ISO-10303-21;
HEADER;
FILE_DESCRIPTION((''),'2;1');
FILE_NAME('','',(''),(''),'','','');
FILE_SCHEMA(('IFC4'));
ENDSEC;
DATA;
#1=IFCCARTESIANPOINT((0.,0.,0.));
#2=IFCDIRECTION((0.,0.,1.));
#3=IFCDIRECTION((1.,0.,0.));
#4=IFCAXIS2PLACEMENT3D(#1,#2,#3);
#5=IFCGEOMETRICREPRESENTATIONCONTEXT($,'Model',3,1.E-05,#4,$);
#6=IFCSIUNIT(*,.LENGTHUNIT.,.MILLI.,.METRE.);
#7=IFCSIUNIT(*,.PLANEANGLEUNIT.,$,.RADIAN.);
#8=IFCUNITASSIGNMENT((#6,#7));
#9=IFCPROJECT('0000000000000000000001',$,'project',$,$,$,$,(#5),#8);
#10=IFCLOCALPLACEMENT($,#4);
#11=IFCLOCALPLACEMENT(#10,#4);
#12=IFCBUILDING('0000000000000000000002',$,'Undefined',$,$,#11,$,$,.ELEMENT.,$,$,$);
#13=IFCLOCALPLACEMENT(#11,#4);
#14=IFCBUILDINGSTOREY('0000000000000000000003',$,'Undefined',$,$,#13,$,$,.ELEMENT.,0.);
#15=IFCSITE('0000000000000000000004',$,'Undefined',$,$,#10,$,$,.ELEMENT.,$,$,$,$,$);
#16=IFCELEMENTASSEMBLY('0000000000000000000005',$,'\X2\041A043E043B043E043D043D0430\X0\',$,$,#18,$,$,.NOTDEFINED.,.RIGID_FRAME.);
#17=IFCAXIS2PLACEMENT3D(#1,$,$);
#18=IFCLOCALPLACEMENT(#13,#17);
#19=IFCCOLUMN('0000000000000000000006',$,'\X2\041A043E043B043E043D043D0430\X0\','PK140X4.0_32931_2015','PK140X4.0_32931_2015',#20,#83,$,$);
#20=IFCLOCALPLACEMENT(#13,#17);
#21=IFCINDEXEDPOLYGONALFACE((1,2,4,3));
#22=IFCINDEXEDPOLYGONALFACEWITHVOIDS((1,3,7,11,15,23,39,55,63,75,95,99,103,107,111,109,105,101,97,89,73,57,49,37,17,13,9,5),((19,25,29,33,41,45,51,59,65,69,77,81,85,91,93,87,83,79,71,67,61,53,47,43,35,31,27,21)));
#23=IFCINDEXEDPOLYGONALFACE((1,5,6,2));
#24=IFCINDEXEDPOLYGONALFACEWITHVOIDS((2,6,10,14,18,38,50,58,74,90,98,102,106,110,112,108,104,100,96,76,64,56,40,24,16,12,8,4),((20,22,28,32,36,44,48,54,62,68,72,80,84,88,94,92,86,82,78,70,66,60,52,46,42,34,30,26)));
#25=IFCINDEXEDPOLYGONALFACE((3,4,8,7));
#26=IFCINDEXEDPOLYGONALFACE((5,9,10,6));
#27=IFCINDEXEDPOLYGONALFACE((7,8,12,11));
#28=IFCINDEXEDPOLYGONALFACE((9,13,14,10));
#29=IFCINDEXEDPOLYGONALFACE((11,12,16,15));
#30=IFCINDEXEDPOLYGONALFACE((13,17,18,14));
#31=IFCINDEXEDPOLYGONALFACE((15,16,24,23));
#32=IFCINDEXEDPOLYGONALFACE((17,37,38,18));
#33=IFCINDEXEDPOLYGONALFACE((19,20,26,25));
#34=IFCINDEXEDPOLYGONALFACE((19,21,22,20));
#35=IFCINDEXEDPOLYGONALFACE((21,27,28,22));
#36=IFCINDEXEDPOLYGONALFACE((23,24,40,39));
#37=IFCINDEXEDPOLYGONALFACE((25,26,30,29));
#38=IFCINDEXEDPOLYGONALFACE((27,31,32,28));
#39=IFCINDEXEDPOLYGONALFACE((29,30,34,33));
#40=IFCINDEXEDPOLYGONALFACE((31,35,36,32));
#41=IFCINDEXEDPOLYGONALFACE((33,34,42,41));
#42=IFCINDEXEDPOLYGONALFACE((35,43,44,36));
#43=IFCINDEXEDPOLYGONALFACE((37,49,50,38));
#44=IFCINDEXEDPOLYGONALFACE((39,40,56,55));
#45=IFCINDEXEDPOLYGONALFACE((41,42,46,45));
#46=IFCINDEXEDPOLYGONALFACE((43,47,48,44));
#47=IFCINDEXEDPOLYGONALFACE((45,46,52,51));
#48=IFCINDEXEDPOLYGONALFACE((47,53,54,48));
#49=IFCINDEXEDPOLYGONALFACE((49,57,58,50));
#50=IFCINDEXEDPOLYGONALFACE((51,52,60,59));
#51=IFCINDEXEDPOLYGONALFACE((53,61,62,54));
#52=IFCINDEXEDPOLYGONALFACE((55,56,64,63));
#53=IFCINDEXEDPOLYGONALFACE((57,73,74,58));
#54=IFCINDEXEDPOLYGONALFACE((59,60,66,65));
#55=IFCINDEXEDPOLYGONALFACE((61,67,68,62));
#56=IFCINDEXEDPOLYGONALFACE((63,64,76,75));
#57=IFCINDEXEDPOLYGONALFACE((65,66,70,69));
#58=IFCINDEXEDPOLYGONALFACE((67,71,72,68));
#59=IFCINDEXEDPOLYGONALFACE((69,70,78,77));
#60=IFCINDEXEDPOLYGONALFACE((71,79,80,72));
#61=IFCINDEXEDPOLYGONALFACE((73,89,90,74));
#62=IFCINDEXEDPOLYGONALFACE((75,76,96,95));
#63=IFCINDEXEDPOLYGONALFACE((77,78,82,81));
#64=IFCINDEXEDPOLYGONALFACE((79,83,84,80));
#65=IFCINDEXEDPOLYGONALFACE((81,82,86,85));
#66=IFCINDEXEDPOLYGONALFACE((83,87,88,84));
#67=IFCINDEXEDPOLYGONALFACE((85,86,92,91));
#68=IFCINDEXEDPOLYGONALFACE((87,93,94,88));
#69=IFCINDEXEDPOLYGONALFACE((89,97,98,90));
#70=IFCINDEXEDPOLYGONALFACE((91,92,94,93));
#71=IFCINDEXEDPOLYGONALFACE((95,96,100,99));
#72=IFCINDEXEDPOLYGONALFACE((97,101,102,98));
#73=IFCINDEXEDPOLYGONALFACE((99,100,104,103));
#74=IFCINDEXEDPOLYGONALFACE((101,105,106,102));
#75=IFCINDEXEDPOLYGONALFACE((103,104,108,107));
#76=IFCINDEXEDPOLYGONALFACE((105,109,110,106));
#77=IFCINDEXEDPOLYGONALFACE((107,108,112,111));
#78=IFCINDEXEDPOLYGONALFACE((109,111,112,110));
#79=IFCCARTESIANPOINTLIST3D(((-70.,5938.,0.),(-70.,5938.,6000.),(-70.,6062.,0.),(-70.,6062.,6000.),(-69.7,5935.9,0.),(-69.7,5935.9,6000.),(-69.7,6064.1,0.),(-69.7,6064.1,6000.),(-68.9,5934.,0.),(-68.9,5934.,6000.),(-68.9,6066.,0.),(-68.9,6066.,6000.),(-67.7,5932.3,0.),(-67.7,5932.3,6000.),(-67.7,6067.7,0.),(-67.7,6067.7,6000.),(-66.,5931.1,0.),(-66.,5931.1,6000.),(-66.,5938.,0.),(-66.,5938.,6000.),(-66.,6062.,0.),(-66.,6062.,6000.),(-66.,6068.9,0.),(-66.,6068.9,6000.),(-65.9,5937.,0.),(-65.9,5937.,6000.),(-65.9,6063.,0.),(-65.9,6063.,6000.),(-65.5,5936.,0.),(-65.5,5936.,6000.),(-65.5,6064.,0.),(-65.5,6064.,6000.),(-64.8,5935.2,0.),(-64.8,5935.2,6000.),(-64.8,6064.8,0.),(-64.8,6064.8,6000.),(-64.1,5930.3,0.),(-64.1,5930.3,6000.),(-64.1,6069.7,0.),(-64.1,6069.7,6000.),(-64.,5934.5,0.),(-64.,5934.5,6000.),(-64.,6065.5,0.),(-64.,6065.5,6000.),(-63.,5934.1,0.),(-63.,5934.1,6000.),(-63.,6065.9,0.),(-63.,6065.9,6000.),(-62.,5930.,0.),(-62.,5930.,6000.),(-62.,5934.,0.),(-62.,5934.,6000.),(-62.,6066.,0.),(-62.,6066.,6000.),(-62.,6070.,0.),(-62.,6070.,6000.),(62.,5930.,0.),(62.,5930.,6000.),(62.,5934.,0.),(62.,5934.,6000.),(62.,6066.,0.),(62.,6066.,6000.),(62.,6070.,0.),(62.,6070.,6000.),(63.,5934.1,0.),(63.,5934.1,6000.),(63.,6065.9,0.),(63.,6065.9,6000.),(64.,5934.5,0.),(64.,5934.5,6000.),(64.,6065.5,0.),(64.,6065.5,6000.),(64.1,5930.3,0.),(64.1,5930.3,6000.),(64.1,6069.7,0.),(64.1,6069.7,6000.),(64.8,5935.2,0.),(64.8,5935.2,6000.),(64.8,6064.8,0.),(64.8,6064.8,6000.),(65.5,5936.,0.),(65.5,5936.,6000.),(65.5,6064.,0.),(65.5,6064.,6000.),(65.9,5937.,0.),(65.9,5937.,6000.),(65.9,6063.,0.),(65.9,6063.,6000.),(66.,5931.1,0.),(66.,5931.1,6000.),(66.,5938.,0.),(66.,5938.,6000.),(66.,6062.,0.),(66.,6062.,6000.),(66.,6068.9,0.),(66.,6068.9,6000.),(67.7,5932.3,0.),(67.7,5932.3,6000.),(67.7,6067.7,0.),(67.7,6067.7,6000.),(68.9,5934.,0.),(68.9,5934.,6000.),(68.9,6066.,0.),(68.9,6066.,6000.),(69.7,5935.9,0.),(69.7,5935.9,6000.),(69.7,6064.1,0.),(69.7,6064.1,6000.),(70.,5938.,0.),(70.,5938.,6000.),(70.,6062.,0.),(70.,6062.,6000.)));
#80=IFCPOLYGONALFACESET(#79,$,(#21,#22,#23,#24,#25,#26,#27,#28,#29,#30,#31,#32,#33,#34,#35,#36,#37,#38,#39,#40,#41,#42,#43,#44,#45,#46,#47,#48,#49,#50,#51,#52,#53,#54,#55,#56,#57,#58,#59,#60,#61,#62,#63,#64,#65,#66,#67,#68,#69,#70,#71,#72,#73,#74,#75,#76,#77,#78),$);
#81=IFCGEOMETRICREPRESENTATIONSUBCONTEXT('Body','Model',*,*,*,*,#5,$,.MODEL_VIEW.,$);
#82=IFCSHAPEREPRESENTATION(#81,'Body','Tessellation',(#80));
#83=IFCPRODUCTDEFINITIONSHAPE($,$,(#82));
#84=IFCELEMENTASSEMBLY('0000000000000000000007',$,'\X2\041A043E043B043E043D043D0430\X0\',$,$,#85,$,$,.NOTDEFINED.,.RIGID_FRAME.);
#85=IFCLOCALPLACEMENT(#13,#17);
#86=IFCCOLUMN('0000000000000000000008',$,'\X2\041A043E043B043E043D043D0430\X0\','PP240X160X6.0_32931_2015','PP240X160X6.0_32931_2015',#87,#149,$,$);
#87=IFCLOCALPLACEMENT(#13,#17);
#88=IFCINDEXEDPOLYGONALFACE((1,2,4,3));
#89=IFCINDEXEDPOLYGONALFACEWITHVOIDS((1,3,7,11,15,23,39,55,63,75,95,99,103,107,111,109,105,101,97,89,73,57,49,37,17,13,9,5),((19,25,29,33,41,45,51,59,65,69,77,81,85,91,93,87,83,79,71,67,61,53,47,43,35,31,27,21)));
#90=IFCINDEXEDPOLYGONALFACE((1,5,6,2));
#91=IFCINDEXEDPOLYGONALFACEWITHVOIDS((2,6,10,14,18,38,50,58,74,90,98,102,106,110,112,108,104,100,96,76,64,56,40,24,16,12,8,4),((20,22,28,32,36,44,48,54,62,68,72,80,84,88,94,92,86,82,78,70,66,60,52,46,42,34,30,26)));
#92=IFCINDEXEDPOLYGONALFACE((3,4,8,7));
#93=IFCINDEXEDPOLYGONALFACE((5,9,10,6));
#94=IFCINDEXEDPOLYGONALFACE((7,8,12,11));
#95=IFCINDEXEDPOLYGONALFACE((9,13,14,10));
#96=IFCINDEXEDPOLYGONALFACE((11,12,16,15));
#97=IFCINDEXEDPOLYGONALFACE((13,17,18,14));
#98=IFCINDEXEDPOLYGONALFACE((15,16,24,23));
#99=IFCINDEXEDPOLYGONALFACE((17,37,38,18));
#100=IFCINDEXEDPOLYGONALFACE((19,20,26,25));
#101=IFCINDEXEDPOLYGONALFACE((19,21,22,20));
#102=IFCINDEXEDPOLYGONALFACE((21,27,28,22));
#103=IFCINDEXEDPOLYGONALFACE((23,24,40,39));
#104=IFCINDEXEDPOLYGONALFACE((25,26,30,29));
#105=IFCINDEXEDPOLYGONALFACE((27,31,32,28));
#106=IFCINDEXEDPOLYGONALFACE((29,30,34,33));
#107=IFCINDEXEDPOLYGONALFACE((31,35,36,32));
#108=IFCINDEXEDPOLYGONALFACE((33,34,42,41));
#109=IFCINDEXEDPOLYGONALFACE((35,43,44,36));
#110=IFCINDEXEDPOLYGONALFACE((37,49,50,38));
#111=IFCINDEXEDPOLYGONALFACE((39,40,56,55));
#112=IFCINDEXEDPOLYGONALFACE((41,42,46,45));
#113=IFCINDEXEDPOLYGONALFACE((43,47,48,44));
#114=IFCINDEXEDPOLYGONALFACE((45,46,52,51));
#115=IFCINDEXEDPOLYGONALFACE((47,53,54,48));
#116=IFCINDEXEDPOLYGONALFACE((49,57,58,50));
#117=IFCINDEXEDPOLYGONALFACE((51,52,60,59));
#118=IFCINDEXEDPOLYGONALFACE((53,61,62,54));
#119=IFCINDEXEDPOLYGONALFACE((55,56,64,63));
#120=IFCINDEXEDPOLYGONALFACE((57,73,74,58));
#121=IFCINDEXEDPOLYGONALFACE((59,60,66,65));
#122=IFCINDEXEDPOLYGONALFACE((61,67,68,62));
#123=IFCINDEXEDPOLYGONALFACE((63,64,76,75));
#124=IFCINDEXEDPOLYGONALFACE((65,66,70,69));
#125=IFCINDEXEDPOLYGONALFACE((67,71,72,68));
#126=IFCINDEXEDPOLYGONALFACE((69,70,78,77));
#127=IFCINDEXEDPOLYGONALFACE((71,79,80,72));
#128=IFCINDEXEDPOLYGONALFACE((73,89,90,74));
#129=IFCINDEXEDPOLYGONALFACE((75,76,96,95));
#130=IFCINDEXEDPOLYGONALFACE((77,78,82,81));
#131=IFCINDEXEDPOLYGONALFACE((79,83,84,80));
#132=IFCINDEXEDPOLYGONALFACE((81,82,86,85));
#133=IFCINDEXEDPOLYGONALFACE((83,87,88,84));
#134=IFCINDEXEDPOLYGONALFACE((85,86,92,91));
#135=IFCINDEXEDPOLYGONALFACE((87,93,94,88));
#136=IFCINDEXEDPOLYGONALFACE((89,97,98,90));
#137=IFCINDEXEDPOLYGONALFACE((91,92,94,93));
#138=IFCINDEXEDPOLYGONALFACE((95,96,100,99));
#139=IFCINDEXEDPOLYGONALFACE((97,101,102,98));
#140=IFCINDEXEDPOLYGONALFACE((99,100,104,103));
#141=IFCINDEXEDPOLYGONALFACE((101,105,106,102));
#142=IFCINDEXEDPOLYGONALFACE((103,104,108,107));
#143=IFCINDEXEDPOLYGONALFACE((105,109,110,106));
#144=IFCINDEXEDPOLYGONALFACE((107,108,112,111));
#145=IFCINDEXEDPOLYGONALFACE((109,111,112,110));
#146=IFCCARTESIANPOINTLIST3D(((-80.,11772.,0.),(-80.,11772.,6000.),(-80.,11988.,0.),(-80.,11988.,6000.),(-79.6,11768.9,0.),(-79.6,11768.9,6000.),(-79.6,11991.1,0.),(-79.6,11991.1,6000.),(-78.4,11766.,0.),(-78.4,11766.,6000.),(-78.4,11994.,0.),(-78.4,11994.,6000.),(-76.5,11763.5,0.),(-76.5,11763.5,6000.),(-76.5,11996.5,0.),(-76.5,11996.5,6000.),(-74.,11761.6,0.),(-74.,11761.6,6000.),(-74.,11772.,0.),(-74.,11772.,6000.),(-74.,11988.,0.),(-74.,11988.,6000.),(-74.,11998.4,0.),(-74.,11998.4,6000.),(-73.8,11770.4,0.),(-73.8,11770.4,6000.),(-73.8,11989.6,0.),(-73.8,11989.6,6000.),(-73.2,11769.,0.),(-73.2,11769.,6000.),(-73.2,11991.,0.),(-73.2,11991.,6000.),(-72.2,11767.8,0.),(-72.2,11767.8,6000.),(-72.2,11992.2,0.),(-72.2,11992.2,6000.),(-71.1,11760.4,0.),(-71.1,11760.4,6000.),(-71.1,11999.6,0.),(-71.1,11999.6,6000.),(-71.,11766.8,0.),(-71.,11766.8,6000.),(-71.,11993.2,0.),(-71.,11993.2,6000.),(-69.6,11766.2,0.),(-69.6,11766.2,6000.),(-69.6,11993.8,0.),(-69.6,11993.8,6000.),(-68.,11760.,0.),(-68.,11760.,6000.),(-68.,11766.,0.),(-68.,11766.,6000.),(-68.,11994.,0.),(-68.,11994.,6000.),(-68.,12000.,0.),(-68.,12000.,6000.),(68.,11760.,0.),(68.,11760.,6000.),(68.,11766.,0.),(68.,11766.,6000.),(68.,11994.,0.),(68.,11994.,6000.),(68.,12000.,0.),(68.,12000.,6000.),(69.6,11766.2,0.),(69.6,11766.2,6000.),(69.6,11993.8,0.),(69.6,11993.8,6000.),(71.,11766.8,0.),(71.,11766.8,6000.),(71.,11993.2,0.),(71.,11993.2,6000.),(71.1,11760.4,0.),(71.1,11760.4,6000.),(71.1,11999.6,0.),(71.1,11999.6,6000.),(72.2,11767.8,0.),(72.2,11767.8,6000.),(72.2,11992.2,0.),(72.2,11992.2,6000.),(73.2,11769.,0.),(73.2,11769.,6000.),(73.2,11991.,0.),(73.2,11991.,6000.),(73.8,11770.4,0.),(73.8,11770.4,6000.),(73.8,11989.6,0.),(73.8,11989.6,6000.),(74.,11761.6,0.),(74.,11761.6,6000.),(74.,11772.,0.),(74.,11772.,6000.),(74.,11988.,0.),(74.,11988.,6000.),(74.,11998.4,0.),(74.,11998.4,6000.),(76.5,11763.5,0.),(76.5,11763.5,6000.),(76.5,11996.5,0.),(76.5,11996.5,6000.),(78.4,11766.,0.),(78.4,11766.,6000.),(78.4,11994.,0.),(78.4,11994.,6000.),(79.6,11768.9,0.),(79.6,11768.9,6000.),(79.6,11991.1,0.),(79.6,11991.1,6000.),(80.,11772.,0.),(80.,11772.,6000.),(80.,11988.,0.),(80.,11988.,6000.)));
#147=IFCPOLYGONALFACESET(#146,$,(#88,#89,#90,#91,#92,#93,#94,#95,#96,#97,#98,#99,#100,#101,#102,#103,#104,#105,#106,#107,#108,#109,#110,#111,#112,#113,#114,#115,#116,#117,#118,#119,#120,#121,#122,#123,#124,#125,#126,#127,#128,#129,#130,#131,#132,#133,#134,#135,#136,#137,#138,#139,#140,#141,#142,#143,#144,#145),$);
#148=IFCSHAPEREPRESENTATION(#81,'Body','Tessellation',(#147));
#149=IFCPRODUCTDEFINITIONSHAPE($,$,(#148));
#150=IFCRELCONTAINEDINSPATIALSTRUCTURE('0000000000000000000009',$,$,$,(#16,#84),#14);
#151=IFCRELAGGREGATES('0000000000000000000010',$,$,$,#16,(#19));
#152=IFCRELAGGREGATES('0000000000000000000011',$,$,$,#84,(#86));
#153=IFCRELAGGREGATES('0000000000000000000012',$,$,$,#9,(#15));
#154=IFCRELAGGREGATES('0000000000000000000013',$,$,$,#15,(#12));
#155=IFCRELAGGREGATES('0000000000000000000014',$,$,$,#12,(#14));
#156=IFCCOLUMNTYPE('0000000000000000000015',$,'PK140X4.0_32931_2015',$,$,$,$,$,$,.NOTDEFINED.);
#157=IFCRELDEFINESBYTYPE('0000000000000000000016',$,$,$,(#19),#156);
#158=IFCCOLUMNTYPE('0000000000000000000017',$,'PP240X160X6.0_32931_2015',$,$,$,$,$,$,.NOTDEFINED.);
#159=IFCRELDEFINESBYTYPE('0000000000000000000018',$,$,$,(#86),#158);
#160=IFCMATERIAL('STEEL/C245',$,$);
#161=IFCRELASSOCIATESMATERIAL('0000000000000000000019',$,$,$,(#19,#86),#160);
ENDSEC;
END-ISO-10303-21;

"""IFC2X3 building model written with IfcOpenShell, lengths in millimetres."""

from ifc_helpers import new_model, si_unit, frame, origin_with_axes, origin_2d_with_axis, place, context, subcontext, project, spatial, hollow_rectangle, extrude, material, type_object, element, aggregate, save


model = new_model("IFC2X3")

# Units and contexts
model_context = context("Model", 3, precision=1e-05, world=origin_with_axes())
body_context = subcontext(model_context, "Body", "Model", "MODEL_VIEW")
ifc_project = project(units=[si_unit("LENGTHUNIT", "METRE", prefix="MILLI"), si_unit("PLANEANGLEUNIT", "RADIAN")], contexts=[model_context])

# Site, building, storey
site_placement = place(None, origin_with_axes())
site = spatial("IfcSite", under=ifc_project, at=site_placement, Name="Undefined", CompositionType="ELEMENT")
building_placement = place(site_placement, origin_with_axes())
building = spatial("IfcBuilding", under=site, at=building_placement, Name="Undefined", CompositionType="ELEMENT")
storey_placement = place(building_placement, origin_with_axes())
storey = spatial("IfcBuildingStorey", under=building, at=storey_placement, Name="Undefined", CompositionType="ELEMENT", Elevation=0.0)

# Element assemblies, columns
assembly_1_placement = place(storey_placement, origin_with_axes())
assembly_1 = element("IfcElementAssembly", 1, at=assembly_1_placement, inside=storey, Name="Колонна", AssemblyPlace="NOTDEFINED", PredefinedType="RIGID_FRAME")
ifc_material = material(Name="STEEL/C245")
column_type_1 = type_object("IfcColumnType", Name="PK140X4.0_32931_2015", PredefinedType="NOTDEFINED")
column_1_placement = place(assembly_1_placement, frame((0.0, 6000.0, 0.0), z_axis=(0.0, 0.0, 1.0), x_axis=(0.0, 1.0, 0.0)))
column_1 = element("IfcColumn", 2, at=column_1_placement, type_object=column_type_1, material=ifc_material, Name="Колонна", Description="PK140X4.0_32931_2015", ObjectType="PK140X4.0_32931_2015", context=body_context, shape_type="SweptSolid", body=[
    extrude(hollow_rectangle(XDim=140.0, YDim=140.0, WallThickness=4.0, InnerFilletRadius=4.0, OuterFilletRadius=8.0, at=origin_2d_with_axis()), frame((0.0, 0.0, 6000.0), z_axis=(0.0, 0.0, -1.0), x_axis=(0.0, 1.0, 0.0)), (0.0, 0.0, 1.0), 6000.0),
])
aggregate(assembly_1, [column_1])
assembly_2_placement = place(storey_placement, origin_with_axes())
assembly_2 = element("IfcElementAssembly", 3, at=assembly_2_placement, inside=storey, Name="Колонна", AssemblyPlace="NOTDEFINED", PredefinedType="RIGID_FRAME")
column_type_2 = type_object("IfcColumnType", Name="PP240X160X6.0_32931_2015", PredefinedType="NOTDEFINED")
column_2_placement = place(assembly_2_placement, frame((0.0, 11880.0, 0.0), z_axis=(0.0, 0.0, 1.0), x_axis=(0.0, -1.0, 0.0)))
column_2 = element("IfcColumn", 4, at=column_2_placement, type_object=column_type_2, material=ifc_material, Name="Колонна", Description="PP240X160X6.0_32931_2015", ObjectType="PP240X160X6.0_32931_2015", context=body_context, shape_type="SweptSolid", body=[
    extrude(hollow_rectangle(XDim=160.0, YDim=240.0, WallThickness=6.0, InnerFilletRadius=6.0, OuterFilletRadius=12.0, at=origin_2d_with_axis()), frame((0.0, 0.0, 6000.0), z_axis=(0.0, 0.0, -1.0), x_axis=(0.0, 1.0, 0.0)), (0.0, 0.0, 1.0), 6000.0),
])
aggregate(assembly_2, [column_2])

save(model, "model.ifc")
